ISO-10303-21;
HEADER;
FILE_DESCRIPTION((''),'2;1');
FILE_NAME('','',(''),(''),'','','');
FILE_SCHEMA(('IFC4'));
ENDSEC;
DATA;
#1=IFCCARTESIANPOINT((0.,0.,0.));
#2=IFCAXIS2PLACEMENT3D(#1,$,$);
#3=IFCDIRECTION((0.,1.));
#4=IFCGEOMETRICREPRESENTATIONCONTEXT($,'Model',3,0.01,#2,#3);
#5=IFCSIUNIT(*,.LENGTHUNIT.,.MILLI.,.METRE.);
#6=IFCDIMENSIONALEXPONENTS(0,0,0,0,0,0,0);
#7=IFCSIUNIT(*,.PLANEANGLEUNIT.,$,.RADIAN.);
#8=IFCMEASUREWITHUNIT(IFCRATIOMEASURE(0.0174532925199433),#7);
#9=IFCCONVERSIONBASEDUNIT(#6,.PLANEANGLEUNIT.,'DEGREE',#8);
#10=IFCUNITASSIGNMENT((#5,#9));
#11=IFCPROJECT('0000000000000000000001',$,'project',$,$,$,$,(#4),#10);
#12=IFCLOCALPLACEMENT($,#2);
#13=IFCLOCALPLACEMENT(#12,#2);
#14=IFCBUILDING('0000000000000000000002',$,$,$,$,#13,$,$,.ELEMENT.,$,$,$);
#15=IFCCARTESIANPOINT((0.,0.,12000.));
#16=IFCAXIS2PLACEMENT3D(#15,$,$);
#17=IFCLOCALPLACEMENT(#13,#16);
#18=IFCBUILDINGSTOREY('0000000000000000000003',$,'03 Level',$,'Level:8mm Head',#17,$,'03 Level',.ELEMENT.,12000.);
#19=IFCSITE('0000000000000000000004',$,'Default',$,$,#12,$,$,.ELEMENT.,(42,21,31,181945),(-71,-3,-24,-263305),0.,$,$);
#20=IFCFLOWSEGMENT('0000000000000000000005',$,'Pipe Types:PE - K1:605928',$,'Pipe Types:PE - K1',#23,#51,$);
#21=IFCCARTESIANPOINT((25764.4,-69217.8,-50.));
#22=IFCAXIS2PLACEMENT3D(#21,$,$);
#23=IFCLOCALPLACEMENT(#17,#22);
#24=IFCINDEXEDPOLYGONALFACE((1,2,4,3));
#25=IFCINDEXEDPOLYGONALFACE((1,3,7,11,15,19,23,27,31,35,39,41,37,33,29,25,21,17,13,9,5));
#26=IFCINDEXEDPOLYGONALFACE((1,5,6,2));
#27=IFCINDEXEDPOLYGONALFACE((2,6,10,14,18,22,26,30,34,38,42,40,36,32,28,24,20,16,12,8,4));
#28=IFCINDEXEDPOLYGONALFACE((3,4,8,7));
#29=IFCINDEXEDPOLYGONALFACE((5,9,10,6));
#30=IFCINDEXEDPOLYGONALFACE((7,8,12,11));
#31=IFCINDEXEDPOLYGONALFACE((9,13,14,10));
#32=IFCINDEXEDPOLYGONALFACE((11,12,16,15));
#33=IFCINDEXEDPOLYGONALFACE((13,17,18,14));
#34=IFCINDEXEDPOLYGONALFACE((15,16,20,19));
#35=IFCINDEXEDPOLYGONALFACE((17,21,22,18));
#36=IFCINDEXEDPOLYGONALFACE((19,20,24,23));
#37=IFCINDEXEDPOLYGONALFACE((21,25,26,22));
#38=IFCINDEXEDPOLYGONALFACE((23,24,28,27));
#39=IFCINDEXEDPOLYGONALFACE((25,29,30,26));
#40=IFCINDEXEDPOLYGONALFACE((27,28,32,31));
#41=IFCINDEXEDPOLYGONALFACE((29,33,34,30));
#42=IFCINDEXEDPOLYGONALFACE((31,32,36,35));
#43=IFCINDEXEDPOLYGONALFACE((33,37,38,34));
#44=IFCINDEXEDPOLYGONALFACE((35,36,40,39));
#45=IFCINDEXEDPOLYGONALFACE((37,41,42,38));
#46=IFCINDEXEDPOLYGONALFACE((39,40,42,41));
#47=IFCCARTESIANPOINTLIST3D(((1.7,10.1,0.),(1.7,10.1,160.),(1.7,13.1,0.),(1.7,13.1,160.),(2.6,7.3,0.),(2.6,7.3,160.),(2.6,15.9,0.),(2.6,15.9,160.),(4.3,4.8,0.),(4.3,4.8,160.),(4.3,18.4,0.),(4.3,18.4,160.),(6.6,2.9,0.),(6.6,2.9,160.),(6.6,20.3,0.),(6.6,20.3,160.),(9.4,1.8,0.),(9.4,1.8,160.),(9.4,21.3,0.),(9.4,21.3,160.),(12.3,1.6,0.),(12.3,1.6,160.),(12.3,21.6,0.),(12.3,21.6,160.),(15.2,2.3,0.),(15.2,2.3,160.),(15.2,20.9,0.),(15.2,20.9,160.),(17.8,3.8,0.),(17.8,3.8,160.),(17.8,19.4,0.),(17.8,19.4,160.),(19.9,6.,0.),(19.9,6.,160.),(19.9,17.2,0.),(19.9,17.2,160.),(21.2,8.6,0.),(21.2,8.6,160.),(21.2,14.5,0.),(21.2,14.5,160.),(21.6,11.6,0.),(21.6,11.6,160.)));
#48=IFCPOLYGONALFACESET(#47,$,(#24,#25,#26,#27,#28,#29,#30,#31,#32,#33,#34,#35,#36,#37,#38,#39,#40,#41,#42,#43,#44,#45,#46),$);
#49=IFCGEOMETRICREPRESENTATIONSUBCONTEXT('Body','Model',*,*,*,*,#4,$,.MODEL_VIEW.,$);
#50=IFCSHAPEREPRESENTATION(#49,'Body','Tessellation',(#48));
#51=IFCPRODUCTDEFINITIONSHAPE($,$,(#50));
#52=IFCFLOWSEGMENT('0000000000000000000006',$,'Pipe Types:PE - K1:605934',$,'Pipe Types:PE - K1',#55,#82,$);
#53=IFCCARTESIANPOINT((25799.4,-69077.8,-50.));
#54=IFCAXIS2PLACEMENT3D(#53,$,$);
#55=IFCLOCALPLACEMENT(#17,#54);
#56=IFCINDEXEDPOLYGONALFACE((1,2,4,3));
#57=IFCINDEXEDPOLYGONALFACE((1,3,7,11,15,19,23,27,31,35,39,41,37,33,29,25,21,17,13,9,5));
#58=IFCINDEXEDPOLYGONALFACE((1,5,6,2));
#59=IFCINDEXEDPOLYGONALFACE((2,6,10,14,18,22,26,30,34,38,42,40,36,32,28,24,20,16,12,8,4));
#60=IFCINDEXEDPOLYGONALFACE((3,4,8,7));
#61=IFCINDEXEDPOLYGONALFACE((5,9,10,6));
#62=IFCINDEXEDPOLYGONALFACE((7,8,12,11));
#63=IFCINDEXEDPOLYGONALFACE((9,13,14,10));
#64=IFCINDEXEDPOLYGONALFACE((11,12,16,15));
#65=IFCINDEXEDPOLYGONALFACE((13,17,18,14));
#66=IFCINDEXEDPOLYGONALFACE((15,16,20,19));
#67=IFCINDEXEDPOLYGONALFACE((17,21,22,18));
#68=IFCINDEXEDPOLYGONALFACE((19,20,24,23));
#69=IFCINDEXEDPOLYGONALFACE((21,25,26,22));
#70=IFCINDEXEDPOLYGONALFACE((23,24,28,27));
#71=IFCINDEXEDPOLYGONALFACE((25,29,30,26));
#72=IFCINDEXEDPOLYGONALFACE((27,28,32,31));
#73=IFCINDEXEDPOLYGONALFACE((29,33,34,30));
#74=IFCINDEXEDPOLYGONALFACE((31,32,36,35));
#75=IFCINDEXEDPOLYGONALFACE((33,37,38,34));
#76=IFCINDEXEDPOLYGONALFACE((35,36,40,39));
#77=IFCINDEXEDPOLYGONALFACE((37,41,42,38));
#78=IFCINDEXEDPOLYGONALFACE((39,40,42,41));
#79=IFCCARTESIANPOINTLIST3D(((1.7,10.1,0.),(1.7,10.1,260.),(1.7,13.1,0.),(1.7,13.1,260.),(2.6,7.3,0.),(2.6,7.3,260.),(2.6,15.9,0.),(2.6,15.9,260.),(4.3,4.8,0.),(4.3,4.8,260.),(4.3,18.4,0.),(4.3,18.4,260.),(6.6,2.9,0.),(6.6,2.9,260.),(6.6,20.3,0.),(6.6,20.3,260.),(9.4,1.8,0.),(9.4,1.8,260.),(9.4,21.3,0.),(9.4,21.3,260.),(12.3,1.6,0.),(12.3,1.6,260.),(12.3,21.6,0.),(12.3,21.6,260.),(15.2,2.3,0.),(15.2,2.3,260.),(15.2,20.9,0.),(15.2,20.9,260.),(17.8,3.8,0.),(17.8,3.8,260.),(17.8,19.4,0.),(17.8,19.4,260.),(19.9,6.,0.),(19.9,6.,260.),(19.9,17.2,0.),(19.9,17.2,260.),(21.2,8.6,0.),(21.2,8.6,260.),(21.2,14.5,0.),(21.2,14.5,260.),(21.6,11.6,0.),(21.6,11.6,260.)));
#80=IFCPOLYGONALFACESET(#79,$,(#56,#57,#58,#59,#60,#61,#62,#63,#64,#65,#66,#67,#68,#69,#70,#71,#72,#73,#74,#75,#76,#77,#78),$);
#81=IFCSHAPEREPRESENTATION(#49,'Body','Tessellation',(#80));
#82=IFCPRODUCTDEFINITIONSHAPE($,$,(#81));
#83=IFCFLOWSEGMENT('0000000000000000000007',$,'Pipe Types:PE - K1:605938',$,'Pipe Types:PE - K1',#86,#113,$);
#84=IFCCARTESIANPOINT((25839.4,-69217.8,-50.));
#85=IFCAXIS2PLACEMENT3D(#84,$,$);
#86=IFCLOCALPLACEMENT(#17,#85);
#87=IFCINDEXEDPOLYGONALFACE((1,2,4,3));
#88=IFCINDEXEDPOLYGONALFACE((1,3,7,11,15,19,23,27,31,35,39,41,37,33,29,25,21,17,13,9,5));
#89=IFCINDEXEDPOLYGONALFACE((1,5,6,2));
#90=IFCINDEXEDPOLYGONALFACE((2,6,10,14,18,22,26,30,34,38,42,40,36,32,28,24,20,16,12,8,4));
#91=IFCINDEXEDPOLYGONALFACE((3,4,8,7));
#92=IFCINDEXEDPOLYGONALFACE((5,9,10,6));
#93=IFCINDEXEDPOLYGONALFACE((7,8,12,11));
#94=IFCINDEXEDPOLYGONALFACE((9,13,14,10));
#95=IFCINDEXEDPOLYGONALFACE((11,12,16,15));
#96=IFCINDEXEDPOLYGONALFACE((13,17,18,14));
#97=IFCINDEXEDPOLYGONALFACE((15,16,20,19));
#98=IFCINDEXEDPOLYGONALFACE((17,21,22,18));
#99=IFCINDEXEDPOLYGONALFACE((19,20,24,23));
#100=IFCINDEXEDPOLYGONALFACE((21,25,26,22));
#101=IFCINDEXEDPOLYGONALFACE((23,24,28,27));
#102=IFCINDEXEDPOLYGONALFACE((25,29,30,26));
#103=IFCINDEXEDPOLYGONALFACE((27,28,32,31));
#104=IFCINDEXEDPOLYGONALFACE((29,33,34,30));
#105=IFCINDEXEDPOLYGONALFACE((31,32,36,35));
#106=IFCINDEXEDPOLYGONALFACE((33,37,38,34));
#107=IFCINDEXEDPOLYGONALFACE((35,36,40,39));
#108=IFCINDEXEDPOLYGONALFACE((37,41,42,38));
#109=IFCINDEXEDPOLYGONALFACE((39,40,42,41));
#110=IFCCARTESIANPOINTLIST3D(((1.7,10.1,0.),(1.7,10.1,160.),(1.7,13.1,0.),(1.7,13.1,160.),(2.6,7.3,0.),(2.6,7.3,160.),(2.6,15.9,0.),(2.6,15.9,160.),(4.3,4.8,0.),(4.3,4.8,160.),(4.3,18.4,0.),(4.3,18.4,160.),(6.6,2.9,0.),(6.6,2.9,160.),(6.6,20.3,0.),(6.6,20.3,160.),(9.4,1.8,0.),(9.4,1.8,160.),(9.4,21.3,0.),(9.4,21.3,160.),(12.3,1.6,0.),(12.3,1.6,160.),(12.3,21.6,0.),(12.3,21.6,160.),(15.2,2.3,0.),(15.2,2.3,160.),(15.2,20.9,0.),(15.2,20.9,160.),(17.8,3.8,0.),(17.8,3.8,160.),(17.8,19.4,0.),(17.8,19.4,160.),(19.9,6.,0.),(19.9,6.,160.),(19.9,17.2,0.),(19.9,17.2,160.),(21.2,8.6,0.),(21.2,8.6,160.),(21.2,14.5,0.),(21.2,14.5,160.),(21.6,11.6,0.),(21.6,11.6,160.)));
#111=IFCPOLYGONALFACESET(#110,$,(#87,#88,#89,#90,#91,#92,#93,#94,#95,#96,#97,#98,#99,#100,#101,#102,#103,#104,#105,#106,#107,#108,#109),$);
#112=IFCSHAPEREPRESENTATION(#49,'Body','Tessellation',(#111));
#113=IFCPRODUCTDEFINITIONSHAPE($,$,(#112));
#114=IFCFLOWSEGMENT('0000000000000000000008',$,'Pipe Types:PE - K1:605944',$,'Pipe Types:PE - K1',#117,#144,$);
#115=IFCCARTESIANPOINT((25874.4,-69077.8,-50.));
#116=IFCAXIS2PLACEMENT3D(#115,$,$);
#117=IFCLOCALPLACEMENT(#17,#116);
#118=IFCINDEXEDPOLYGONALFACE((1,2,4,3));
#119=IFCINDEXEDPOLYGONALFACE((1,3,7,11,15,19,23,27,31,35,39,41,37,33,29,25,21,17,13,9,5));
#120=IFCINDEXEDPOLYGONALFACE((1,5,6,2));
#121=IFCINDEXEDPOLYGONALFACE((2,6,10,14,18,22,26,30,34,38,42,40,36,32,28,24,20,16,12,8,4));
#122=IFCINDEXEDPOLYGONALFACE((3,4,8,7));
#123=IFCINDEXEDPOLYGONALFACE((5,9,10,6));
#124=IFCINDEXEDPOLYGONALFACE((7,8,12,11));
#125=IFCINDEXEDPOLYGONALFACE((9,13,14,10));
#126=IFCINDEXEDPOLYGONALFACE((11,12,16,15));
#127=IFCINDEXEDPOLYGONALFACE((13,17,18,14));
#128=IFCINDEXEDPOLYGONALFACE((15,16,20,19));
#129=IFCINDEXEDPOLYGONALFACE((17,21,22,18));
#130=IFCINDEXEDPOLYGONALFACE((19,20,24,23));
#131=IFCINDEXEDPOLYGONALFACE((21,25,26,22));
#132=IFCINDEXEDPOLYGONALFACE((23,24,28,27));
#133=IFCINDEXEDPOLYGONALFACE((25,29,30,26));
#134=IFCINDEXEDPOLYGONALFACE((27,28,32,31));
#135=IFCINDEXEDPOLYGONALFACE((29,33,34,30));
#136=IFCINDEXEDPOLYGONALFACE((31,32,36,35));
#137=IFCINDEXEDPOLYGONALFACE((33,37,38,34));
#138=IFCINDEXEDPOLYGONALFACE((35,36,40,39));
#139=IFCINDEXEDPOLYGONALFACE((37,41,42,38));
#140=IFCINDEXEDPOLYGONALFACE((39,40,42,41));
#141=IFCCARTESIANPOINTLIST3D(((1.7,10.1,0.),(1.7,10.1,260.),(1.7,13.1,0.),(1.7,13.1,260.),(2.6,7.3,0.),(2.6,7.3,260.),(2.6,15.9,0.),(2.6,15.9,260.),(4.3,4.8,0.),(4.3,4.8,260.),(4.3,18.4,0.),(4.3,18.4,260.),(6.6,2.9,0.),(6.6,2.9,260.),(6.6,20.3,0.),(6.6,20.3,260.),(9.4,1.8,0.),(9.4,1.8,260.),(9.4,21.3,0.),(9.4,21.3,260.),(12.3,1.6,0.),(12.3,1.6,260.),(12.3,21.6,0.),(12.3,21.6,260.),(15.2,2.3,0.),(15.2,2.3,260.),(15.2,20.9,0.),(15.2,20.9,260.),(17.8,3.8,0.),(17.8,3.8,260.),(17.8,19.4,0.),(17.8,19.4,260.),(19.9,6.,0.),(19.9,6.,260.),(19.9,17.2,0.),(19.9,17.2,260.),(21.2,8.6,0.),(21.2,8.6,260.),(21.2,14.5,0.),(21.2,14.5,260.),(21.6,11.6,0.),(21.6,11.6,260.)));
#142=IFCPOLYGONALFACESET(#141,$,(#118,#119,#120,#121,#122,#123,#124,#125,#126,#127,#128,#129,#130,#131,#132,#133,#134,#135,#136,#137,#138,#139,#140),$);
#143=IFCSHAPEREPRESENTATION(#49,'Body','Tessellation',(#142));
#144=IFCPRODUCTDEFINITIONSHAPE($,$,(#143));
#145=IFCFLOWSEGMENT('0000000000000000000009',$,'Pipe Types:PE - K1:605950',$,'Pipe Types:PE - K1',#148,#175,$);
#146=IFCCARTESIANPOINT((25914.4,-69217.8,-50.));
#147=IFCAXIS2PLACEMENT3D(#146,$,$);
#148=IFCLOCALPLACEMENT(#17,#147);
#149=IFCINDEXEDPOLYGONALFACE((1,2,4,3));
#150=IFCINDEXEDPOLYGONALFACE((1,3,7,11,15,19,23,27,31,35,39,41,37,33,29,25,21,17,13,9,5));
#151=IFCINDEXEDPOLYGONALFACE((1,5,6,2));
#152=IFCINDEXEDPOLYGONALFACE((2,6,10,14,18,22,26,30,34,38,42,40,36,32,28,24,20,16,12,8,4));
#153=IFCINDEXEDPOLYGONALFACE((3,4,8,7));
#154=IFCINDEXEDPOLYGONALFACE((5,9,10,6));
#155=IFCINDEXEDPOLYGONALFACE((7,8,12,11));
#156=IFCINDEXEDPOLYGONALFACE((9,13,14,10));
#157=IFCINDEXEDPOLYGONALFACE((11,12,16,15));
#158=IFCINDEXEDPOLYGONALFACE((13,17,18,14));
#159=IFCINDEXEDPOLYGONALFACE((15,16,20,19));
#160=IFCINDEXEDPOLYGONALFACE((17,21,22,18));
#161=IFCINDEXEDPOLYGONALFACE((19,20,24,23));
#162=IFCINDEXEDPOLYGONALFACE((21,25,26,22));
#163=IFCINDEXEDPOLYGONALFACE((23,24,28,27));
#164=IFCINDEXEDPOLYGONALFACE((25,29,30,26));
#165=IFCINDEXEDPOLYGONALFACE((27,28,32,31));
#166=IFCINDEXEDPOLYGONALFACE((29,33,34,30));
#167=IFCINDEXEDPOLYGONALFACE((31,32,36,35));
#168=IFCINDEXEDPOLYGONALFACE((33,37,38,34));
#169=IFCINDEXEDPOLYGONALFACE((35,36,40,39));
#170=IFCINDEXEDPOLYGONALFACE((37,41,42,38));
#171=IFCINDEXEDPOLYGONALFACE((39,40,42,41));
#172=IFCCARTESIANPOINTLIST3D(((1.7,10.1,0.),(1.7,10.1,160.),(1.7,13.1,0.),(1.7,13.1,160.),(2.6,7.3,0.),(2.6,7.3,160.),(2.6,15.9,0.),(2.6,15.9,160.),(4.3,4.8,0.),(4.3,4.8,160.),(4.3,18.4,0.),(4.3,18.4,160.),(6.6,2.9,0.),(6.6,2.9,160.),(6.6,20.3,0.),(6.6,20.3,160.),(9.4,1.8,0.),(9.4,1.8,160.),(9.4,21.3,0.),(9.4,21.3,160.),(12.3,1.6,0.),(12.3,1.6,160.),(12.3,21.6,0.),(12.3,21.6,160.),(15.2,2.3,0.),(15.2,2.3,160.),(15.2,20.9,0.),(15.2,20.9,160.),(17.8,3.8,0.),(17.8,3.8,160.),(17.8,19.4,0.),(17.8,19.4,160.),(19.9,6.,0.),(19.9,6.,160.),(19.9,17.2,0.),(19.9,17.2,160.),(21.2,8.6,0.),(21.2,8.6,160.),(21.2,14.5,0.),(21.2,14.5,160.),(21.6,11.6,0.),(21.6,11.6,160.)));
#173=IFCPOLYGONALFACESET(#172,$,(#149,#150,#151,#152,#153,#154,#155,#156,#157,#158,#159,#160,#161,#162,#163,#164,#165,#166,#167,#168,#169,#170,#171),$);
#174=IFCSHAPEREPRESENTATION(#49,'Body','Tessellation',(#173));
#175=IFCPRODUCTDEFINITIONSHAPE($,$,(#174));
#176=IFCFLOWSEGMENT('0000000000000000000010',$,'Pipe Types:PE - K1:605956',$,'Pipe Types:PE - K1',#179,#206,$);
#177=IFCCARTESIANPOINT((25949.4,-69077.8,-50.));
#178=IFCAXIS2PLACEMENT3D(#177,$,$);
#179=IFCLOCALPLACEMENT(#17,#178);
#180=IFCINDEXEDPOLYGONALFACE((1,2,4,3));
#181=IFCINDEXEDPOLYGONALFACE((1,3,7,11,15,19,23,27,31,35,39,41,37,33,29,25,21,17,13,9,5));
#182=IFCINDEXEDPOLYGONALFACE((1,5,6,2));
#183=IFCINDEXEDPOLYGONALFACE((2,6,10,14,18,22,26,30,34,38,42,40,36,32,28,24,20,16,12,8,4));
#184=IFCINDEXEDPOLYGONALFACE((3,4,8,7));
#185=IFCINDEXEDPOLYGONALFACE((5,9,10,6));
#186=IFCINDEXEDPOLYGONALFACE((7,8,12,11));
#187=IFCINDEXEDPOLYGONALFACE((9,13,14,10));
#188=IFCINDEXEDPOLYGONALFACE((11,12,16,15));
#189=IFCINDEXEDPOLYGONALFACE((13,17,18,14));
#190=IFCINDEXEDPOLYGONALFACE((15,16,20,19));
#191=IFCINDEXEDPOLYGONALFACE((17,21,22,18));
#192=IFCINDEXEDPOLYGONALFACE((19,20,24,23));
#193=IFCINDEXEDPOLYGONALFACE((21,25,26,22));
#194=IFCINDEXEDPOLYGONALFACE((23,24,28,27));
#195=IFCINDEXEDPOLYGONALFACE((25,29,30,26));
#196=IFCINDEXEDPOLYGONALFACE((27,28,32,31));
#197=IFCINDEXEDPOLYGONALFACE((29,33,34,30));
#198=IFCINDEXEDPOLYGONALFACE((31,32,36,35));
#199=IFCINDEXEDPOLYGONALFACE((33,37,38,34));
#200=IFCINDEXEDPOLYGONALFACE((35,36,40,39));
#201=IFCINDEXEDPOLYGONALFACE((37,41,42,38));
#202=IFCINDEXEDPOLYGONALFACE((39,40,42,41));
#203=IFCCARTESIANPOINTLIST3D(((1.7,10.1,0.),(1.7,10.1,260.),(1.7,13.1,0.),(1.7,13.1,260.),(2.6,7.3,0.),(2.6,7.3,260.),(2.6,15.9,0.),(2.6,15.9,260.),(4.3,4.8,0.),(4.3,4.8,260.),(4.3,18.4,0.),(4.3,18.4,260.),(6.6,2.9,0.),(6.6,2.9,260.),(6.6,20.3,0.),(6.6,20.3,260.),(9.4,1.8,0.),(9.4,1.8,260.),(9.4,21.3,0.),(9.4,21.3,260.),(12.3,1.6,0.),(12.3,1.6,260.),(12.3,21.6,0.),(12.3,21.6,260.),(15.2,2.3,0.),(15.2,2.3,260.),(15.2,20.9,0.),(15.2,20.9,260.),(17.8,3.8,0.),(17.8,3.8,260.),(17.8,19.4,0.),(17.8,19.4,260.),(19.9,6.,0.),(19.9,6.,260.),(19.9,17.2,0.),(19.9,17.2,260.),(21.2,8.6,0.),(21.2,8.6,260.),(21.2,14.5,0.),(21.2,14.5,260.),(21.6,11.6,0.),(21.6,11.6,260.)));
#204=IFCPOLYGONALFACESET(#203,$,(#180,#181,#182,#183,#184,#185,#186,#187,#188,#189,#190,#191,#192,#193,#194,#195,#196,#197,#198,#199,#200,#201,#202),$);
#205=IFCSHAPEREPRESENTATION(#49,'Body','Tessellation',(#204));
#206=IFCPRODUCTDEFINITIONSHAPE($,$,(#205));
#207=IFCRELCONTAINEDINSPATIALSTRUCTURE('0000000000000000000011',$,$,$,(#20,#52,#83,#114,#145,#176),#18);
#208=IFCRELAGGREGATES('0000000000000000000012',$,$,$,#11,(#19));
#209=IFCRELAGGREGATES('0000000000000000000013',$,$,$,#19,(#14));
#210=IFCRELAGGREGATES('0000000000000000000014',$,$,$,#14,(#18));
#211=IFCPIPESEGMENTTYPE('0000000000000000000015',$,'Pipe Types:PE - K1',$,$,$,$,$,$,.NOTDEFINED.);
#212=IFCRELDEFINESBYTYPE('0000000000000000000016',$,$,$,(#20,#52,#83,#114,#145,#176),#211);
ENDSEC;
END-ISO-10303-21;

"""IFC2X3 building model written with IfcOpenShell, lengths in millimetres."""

from ifc_helpers import new_model, entity, si_unit, converted_unit, direction, frame, origin, origin_2d_with_axis, place, context, subcontext, project, spatial, circle, extrude, type_object, element, save


model = new_model("IFC2X3")

# Units and contexts
model_context = context("Model", 3, precision=0.01, world=origin(), true_north=direction((0.0, 1.0)))
body_context = subcontext(model_context, "Body", "Model", "MODEL_VIEW")
ifc_project = project(units=[si_unit("LENGTHUNIT", "METRE", prefix="MILLI"), converted_unit("PLANEANGLEUNIT", "DEGREE", entity("IfcRatioMeasure", 0.0174532925199433), si_unit("PLANEANGLEUNIT", "RADIAN"), dimensions=[0, 0, 0, 0, 0, 0, 0])], contexts=[model_context])

# Site, building, storey
site_placement = place(None, origin())
site = spatial("IfcSite", under=ifc_project, at=site_placement, Name="Default", CompositionType="ELEMENT", RefLatitude=(42, 21, 31, 181945), RefLongitude=(-71, -3, -24, -263305), RefElevation=0.0)
building_placement = place(site_placement, origin())
building = spatial("IfcBuilding", under=site, at=building_placement, CompositionType="ELEMENT")
storey_placement = place(building_placement, frame((0.0, 0.0, 12000.0)))
storey = spatial("IfcBuildingStorey", under=building, at=storey_placement, Name="03 Level", ObjectType="Level:8mm Head", LongName="03 Level", CompositionType="ELEMENT", Elevation=12000.0)

# Flow segments
pipe_segment_type = type_object("IfcPipeSegmentType", Name="Pipe Types:PE - K1", PredefinedType="NOTDEFINED")
flow_segment_1_placement = place(storey_placement, frame((25764.4, -69217.8, -50.0)))
element("IfcFlowSegment", 1, at=flow_segment_1_placement, inside=storey, type_object=pipe_segment_type, Name="Pipe Types:PE - K1:605928", ObjectType="Pipe Types:PE - K1", context=body_context, shape_type="SweptSolid", body=[
    extrude(circle(Radius=10.0, at=origin_2d_with_axis()), frame((11.6, 11.6, 0.0)), (0.0, 0.0, 1.0), 160.0),
])
flow_segment_2_placement = place(storey_placement, frame((25799.4, -69077.8, -50.0)))
element("IfcFlowSegment", 2, at=flow_segment_2_placement, inside=storey, type_object=pipe_segment_type, Name="Pipe Types:PE - K1:605934", ObjectType="Pipe Types:PE - K1", context=body_context, shape_type="SweptSolid", body=[
    extrude(circle(Radius=10.0, at=origin_2d_with_axis()), frame((11.6, 11.6, 0.0)), (0.0, 0.0, 1.0), 260.0),
])
flow_segment_3_placement = place(storey_placement, frame((25839.4, -69217.8, -50.0)))
element("IfcFlowSegment", 3, at=flow_segment_3_placement, inside=storey, type_object=pipe_segment_type, Name="Pipe Types:PE - K1:605938", ObjectType="Pipe Types:PE - K1", context=body_context, shape_type="SweptSolid", body=[
    extrude(circle(Radius=10.0, at=origin_2d_with_axis()), frame((11.6, 11.6, 0.0)), (0.0, 0.0, 1.0), 160.0),
])
flow_segment_4_placement = place(storey_placement, frame((25874.4, -69077.8, -50.0)))
element("IfcFlowSegment", 4, at=flow_segment_4_placement, inside=storey, type_object=pipe_segment_type, Name="Pipe Types:PE - K1:605944", ObjectType="Pipe Types:PE - K1", context=body_context, shape_type="SweptSolid", body=[
    extrude(circle(Radius=10.0, at=origin_2d_with_axis()), frame((11.6, 11.6, 0.0)), (0.0, 0.0, 1.0), 260.0),
])
flow_segment_5_placement = place(storey_placement, frame((25914.4, -69217.8, -50.0)))
element("IfcFlowSegment", 5, at=flow_segment_5_placement, inside=storey, type_object=pipe_segment_type, Name="Pipe Types:PE - K1:605950", ObjectType="Pipe Types:PE - K1", context=body_context, shape_type="SweptSolid", body=[
    extrude(circle(Radius=10.0, at=origin_2d_with_axis()), frame((11.6, 11.6, 0.0)), (0.0, 0.0, 1.0), 160.0),
])
flow_segment_6_placement = place(storey_placement, frame((25949.4, -69077.8, -50.0)))
element("IfcFlowSegment", 6, at=flow_segment_6_placement, inside=storey, type_object=pipe_segment_type, Name="Pipe Types:PE - K1:605956", ObjectType="Pipe Types:PE - K1", context=body_context, shape_type="SweptSolid", body=[
    extrude(circle(Radius=10.0, at=origin_2d_with_axis()), frame((11.6, 11.6, 0.0)), (0.0, 0.0, 1.0), 260.0),
])

save(model, "model.ifc")
